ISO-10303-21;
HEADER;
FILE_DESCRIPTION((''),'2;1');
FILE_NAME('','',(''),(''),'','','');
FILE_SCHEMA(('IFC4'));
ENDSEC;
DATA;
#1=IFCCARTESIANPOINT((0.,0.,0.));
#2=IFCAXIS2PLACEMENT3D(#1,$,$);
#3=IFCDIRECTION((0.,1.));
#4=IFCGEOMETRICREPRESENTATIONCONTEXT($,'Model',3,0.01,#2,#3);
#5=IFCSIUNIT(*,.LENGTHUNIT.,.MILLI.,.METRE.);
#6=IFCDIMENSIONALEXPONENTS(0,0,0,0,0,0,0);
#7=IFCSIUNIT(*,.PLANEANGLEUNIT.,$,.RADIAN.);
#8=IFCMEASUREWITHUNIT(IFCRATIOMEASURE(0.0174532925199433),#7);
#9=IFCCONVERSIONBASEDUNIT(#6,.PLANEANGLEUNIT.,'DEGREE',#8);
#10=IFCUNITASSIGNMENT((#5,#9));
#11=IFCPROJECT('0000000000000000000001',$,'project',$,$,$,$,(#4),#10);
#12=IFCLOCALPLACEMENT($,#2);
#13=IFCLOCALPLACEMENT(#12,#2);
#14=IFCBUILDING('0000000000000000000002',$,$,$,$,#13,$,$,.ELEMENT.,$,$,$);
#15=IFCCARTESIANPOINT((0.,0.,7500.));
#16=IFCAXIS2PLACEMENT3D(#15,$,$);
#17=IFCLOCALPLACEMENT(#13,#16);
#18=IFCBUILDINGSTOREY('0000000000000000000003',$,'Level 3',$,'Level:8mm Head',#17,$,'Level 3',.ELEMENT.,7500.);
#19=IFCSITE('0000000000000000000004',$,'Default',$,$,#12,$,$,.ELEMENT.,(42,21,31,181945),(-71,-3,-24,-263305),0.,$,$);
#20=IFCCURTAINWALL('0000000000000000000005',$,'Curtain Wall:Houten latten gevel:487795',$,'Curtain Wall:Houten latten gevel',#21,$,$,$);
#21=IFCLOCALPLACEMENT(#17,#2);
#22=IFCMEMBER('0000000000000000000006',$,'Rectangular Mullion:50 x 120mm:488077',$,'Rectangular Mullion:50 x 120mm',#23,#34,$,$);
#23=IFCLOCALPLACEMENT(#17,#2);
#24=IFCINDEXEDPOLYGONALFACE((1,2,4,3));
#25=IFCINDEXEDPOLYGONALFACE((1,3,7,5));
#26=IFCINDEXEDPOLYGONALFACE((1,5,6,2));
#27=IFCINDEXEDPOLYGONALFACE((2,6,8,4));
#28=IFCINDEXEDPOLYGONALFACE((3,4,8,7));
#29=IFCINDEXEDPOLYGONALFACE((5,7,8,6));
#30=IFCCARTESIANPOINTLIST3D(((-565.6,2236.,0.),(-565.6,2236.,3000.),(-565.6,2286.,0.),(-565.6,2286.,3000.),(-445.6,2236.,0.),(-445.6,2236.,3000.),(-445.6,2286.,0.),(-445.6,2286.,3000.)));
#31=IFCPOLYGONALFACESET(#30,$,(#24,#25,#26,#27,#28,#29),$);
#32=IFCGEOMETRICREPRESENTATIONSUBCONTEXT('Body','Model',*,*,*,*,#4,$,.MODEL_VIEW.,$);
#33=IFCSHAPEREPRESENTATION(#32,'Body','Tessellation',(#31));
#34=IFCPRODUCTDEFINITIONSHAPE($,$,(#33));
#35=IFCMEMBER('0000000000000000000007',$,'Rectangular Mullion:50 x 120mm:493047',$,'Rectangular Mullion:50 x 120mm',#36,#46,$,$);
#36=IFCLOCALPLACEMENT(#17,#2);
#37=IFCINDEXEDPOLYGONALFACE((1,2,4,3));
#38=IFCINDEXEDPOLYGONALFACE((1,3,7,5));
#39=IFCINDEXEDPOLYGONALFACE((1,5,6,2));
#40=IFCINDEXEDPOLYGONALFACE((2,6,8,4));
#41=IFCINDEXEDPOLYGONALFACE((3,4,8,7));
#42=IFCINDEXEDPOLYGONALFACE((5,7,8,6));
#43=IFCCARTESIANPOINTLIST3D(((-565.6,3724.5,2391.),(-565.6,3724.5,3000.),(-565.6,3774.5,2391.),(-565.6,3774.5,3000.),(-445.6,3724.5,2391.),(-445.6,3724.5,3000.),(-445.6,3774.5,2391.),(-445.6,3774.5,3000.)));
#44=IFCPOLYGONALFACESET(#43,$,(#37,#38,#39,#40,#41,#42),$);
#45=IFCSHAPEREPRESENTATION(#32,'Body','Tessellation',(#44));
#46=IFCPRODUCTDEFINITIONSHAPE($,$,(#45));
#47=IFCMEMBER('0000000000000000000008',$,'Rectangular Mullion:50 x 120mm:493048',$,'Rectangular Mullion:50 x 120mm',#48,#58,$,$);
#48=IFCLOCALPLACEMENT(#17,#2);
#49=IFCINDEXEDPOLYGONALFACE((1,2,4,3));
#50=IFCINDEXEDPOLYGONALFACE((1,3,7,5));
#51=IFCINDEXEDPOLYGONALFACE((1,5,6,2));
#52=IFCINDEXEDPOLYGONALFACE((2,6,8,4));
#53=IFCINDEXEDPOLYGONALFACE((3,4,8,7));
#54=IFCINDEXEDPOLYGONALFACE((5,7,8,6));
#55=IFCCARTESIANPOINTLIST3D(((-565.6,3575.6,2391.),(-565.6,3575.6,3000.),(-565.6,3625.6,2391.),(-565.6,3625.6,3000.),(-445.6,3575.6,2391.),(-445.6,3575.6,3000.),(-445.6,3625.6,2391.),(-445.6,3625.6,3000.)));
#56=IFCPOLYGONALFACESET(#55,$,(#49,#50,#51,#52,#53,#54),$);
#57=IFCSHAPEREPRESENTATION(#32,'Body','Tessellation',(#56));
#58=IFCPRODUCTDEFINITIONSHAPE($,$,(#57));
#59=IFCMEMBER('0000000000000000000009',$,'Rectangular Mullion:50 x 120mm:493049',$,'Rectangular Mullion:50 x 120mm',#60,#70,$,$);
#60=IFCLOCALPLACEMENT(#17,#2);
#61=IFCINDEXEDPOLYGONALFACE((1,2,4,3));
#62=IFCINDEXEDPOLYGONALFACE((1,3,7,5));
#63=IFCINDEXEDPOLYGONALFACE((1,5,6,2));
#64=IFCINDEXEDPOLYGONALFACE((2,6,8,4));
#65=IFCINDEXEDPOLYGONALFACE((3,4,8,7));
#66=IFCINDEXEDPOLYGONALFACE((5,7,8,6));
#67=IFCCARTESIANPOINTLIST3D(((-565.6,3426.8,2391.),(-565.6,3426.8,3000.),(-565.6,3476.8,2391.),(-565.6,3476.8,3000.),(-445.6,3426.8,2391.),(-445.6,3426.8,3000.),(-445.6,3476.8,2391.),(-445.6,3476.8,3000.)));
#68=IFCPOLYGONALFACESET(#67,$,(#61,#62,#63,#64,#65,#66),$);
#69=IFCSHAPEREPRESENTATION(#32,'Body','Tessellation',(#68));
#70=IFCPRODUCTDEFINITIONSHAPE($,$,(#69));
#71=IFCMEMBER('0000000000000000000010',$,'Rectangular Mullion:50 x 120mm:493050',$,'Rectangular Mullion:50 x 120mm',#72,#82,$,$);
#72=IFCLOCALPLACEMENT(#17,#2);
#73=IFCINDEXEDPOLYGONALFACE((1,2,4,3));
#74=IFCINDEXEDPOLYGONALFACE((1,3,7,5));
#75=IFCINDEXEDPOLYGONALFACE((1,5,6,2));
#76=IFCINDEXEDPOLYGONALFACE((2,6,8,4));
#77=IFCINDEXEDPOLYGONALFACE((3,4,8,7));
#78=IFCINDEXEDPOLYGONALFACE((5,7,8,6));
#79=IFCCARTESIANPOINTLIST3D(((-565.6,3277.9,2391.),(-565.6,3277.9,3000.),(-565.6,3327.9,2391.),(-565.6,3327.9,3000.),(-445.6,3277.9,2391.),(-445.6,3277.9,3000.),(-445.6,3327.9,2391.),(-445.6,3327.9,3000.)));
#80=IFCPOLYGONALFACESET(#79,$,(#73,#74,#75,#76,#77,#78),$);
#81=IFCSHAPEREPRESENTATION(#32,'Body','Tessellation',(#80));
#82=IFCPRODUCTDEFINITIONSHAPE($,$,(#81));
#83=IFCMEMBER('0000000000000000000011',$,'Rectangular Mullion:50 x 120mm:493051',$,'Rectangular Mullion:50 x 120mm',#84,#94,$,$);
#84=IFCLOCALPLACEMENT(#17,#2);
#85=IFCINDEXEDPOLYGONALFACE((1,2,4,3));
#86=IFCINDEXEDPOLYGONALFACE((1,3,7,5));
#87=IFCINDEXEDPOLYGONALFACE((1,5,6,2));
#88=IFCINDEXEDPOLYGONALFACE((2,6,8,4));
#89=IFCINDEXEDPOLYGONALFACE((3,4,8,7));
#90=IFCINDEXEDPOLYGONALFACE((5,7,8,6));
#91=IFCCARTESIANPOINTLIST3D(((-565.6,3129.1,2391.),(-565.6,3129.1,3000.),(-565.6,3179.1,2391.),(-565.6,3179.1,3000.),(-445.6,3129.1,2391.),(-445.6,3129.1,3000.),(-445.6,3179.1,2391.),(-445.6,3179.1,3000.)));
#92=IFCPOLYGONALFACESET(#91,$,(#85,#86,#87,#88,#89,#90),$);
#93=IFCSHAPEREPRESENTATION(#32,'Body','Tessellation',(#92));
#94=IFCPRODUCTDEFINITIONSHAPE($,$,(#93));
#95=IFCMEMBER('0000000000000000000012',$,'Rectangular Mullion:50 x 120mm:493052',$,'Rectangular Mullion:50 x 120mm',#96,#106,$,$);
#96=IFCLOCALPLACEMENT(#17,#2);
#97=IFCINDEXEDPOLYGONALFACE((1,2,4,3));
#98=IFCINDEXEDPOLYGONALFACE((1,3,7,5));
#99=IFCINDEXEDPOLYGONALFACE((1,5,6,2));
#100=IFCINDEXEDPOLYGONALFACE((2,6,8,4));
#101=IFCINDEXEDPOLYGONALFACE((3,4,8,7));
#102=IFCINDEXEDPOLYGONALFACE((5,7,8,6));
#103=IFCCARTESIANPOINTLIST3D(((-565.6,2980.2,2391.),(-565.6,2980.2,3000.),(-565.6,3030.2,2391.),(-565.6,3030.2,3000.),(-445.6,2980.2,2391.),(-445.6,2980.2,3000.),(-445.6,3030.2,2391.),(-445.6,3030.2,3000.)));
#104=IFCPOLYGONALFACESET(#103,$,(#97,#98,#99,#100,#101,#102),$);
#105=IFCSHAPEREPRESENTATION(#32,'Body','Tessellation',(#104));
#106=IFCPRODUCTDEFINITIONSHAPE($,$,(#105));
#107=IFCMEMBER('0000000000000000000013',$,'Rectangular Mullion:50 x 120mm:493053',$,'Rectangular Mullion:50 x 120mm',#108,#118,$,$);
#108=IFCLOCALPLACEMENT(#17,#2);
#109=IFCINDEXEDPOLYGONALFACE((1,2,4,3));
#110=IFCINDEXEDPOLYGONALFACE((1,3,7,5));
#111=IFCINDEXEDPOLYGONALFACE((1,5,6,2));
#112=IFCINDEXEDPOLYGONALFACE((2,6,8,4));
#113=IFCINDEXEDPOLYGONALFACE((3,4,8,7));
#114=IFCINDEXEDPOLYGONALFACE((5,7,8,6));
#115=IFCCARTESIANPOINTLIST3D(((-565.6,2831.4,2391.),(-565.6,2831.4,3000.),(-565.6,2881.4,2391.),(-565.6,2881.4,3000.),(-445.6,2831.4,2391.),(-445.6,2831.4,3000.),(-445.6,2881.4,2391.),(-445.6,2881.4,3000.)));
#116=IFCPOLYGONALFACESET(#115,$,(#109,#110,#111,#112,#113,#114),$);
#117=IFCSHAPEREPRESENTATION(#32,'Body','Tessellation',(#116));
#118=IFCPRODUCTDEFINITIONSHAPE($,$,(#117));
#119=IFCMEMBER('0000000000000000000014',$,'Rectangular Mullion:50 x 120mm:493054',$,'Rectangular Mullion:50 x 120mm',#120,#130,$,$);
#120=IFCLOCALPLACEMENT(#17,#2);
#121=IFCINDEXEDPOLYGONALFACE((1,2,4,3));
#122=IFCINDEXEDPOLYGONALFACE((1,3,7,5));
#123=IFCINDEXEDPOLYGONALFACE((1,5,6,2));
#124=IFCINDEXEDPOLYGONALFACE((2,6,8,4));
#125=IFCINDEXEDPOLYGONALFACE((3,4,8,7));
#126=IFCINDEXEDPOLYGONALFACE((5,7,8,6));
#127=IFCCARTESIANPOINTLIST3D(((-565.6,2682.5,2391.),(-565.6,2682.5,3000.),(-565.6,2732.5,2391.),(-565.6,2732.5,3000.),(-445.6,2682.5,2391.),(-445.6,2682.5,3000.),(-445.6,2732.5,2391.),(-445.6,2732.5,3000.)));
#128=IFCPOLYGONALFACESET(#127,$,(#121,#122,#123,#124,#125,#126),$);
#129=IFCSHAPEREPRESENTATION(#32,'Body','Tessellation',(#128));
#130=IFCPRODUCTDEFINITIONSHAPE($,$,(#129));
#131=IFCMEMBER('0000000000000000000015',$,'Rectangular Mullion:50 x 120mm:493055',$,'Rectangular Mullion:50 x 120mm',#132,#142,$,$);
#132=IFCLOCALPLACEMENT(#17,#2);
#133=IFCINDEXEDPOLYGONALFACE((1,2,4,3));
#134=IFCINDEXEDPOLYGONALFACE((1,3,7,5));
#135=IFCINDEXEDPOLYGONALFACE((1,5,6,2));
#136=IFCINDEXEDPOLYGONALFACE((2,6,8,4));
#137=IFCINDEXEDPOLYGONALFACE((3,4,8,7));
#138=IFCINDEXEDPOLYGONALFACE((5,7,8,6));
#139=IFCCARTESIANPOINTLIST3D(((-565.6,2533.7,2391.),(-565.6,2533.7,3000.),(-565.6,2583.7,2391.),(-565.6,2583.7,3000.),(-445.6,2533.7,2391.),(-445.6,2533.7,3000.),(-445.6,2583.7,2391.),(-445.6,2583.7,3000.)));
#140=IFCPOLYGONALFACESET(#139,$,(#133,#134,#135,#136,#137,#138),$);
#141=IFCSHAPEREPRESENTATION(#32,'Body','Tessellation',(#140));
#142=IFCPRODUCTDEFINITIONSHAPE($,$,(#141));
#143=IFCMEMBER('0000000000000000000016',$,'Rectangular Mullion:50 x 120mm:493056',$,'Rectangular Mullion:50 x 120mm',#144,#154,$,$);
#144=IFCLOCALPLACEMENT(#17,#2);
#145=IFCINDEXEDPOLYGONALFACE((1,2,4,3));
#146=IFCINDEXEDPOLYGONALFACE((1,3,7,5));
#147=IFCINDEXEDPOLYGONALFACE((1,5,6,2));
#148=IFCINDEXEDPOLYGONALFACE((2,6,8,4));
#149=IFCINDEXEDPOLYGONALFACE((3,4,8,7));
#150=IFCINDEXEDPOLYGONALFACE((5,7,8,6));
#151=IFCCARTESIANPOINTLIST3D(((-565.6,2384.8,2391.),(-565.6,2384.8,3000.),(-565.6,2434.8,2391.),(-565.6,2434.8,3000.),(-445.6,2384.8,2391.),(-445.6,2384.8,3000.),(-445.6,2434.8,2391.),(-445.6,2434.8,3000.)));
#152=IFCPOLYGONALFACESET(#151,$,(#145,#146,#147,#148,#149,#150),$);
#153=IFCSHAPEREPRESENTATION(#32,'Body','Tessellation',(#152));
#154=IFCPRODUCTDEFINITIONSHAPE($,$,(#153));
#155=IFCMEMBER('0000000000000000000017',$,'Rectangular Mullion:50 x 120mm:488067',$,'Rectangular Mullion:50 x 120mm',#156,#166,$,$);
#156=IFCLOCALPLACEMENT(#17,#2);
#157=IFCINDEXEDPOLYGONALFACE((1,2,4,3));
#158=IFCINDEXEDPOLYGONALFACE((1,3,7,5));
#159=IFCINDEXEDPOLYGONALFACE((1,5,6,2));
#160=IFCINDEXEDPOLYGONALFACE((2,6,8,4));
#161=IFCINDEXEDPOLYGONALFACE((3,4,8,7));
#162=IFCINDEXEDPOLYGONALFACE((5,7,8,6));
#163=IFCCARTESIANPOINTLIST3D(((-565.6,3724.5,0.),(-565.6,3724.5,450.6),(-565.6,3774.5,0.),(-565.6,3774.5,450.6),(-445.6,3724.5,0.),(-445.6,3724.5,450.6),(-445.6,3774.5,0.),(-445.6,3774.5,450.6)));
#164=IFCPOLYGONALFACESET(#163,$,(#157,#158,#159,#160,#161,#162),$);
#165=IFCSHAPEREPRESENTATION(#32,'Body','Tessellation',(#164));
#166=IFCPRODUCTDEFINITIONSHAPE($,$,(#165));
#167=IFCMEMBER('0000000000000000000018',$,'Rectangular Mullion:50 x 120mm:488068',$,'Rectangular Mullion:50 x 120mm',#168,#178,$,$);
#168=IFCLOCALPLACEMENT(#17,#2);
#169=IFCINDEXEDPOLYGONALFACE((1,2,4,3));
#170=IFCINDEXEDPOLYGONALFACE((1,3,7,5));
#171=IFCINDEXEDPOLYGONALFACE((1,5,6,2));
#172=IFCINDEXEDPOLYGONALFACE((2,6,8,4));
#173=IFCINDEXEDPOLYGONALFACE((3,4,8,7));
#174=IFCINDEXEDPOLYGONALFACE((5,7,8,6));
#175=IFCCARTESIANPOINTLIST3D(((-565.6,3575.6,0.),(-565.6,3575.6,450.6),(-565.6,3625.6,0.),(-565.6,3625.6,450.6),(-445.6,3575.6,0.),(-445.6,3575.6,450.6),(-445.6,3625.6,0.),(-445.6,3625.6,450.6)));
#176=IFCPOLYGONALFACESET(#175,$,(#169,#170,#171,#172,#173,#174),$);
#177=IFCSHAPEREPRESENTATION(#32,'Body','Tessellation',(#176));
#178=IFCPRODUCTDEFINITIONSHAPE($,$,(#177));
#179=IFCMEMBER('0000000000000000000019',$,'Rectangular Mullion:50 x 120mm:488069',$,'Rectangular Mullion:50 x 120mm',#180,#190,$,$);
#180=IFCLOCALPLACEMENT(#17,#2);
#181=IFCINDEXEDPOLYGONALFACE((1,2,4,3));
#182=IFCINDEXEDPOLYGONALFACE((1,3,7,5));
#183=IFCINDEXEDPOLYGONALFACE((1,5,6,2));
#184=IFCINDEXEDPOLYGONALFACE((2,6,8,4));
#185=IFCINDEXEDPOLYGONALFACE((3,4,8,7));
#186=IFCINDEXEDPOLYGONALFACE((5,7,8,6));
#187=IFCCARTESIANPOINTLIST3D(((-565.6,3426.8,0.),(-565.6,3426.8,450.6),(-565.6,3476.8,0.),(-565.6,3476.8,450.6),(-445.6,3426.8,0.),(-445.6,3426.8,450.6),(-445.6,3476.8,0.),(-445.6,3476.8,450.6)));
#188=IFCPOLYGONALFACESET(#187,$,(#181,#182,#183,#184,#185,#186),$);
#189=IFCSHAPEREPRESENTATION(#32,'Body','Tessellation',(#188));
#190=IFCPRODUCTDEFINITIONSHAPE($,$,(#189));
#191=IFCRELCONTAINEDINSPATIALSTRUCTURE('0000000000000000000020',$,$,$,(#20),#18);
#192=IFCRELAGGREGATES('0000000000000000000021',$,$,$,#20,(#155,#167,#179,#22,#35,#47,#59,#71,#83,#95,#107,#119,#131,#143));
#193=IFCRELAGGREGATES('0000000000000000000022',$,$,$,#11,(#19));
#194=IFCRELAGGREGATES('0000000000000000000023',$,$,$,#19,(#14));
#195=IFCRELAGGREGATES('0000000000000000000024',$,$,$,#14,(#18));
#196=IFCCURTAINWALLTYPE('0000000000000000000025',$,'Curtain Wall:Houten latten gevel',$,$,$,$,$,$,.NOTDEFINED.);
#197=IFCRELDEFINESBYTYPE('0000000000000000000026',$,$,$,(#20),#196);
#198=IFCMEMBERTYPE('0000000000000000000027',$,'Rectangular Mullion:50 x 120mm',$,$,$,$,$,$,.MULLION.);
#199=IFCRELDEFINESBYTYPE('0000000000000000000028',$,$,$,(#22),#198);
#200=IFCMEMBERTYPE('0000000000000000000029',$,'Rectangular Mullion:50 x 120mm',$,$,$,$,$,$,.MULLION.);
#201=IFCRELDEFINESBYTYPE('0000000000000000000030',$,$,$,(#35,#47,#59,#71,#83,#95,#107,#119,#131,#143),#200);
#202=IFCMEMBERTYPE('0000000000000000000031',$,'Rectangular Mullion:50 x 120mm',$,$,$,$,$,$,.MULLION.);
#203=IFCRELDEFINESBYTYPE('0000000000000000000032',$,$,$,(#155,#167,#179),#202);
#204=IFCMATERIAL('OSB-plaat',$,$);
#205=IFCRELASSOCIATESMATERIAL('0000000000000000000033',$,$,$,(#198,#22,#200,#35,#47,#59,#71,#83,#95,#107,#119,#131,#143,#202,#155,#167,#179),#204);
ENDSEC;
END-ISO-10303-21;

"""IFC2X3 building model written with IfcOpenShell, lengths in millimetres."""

from ifc_helpers import new_model, entity, si_unit, converted_unit, direction, frame, origin, origin_2d_with_axis, place, context, subcontext, project, spatial, rectangle, extrude, source, transform, mapped, material, type_object, type_shapes, element, aggregate, save


model = new_model("IFC2X3")

# Units and contexts
model_context = context("Model", 3, precision=0.01, world=origin(), true_north=direction((0.0, 1.0)))
body_context = subcontext(model_context, "Body", "Model", "MODEL_VIEW")
ifc_project = project(units=[si_unit("LENGTHUNIT", "METRE", prefix="MILLI"), converted_unit("PLANEANGLEUNIT", "DEGREE", entity("IfcRatioMeasure", 0.0174532925199433), si_unit("PLANEANGLEUNIT", "RADIAN"), dimensions=[0, 0, 0, 0, 0, 0, 0])], contexts=[model_context])

# Site, building, storey
site_placement = place(None, frame((0.0, 0.0, 0.0)))
site = spatial("IfcSite", under=ifc_project, at=site_placement, Name="Default", CompositionType="ELEMENT", RefLatitude=(42, 21, 31, 181945), RefLongitude=(-71, -3, -24, -263305), RefElevation=0.0)
building_placement = place(site_placement, origin())
building = spatial("IfcBuilding", under=site, at=building_placement, CompositionType="ELEMENT")
storey_placement = place(building_placement, frame((0.0, 0.0, 7500.0)))
storey = spatial("IfcBuildingStorey", under=building, at=storey_placement, Name="Level 3", ObjectType="Level:8mm Head", LongName="Level 3", CompositionType="ELEMENT", Elevation=7500.0)

# Curtain wall, members
curtain_wall_type = type_object("IfcCurtainWallType", Name="Curtain Wall:Houten latten gevel", PredefinedType="NOTDEFINED")
curtain_wall_placement = place(storey_placement, frame((0.0, 0.0, -7500.0)))
curtain_wall = element("IfcCurtainWall", 1, at=curtain_wall_placement, inside=storey, type_object=curtain_wall_type, Name="Curtain Wall:Houten latten gevel:487795", ObjectType="Curtain Wall:Houten latten gevel")
ifc_material_1 = material(Name="OSB-plaat")
member_type_1 = type_object("IfcMemberType", Name="Rectangular Mullion:50 x 120mm", PredefinedType="MULLION", material=ifc_material_1)
shared_shape_1 = source(origin(), body_context, "Body", "SweptSolid", [
    extrude(rectangle(XDim=120.0, YDim=50.0, at=origin_2d_with_axis()), frame((0.0, 0.0, -3000.0), z_axis=(0.0, 0.0, 1.0), x_axis=(0.0, -1.0, 0.0)), (0.0, 0.0, 1.0), 3000.0),
])
type_shapes(member_type_1, [shared_shape_1])
member_1_placement = place(storey_placement, frame((-505.6, 2261.0, 0.0), z_axis=(0.0, 0.0, -1.0), x_axis=(0.0, -1.0, 0.0)))
member_1 = element("IfcMember", 2, at=member_1_placement, type_object=member_type_1, material=ifc_material_1, Name="Rectangular Mullion:50 x 120mm:488077", ObjectType="Rectangular Mullion:50 x 120mm", context=body_context, shape_type="MappedRepresentation", body=[
    mapped(shared_shape_1, transform((0.0, 0.0, 0.0), scale=1.0)),
])
member_type_2 = type_object("IfcMemberType", Name="Rectangular Mullion:50 x 120mm", PredefinedType="MULLION", material=ifc_material_1)
shared_shape_2 = source(origin(), body_context, "Body", "SweptSolid", [
    extrude(rectangle(XDim=120.0, YDim=50.0, at=origin_2d_with_axis()), frame((0.0, 0.0, -609.0), z_axis=(0.0, 0.0, 1.0), x_axis=(0.0, -1.0, 0.0)), (0.0, 0.0, 1.0), 609.0),
])
type_shapes(member_type_2, [shared_shape_2])
member_2_placement = place(storey_placement, frame((-505.6, 3749.5, 2391.0), z_axis=(0.0, 0.0, -1.0), x_axis=(0.0, -1.0, 0.0)))
member_2 = element("IfcMember", 3, at=member_2_placement, type_object=member_type_2, material=ifc_material_1, Name="Rectangular Mullion:50 x 120mm:493047", ObjectType="Rectangular Mullion:50 x 120mm", context=body_context, shape_type="MappedRepresentation", body=[
    mapped(shared_shape_2, transform((0.0, 0.0, 0.0), scale=1.0)),
])
member_3_placement = place(storey_placement, frame((-505.6, 3600.6, 2391.0), z_axis=(0.0, 0.0, -1.0), x_axis=(0.0, -1.0, 0.0)))
member_3 = element("IfcMember", 4, at=member_3_placement, type_object=member_type_2, material=ifc_material_1, Name="Rectangular Mullion:50 x 120mm:493048", ObjectType="Rectangular Mullion:50 x 120mm", context=body_context, shape_type="MappedRepresentation", body=[
    mapped(shared_shape_2, transform((0.0, 0.0, 0.0), scale=1.0)),
])
member_4_placement = place(storey_placement, frame((-505.6, 3451.8, 2391.0), z_axis=(0.0, 0.0, -1.0), x_axis=(0.0, -1.0, 0.0)))
member_4 = element("IfcMember", 5, at=member_4_placement, type_object=member_type_2, material=ifc_material_1, Name="Rectangular Mullion:50 x 120mm:493049", ObjectType="Rectangular Mullion:50 x 120mm", context=body_context, shape_type="MappedRepresentation", body=[
    mapped(shared_shape_2, transform((0.0, 0.0, 0.0), scale=1.0)),
])
member_5_placement = place(storey_placement, frame((-505.6, 3302.9, 2391.0), z_axis=(0.0, 0.0, -1.0), x_axis=(0.0, -1.0, 0.0)))
member_5 = element("IfcMember", 6, at=member_5_placement, type_object=member_type_2, material=ifc_material_1, Name="Rectangular Mullion:50 x 120mm:493050", ObjectType="Rectangular Mullion:50 x 120mm", context=body_context, shape_type="MappedRepresentation", body=[
    mapped(shared_shape_2, transform((0.0, 0.0, 0.0), scale=1.0)),
])
member_6_placement = place(storey_placement, frame((-505.6, 3154.1, 2391.0), z_axis=(0.0, 0.0, -1.0), x_axis=(0.0, -1.0, 0.0)))
member_6 = element("IfcMember", 7, at=member_6_placement, type_object=member_type_2, material=ifc_material_1, Name="Rectangular Mullion:50 x 120mm:493051", ObjectType="Rectangular Mullion:50 x 120mm", context=body_context, shape_type="MappedRepresentation", body=[
    mapped(shared_shape_2, transform((0.0, 0.0, 0.0), scale=1.0)),
])
member_7_placement = place(storey_placement, frame((-505.6, 3005.2, 2391.0), z_axis=(0.0, 0.0, -1.0), x_axis=(0.0, -1.0, 0.0)))
member_7 = element("IfcMember", 8, at=member_7_placement, type_object=member_type_2, material=ifc_material_1, Name="Rectangular Mullion:50 x 120mm:493052", ObjectType="Rectangular Mullion:50 x 120mm", context=body_context, shape_type="MappedRepresentation", body=[
    mapped(shared_shape_2, transform((0.0, 0.0, 0.0), scale=1.0)),
])
member_8_placement = place(storey_placement, frame((-505.6, 2856.4, 2391.0), z_axis=(0.0, 0.0, -1.0), x_axis=(0.0, -1.0, 0.0)))
member_8 = element("IfcMember", 9, at=member_8_placement, type_object=member_type_2, material=ifc_material_1, Name="Rectangular Mullion:50 x 120mm:493053", ObjectType="Rectangular Mullion:50 x 120mm", context=body_context, shape_type="MappedRepresentation", body=[
    mapped(shared_shape_2, transform((0.0, 0.0, 0.0), scale=1.0)),
])
member_9_placement = place(storey_placement, frame((-505.6, 2707.5, 2391.0), z_axis=(0.0, 0.0, -1.0), x_axis=(0.0, -1.0, 0.0)))
member_9 = element("IfcMember", 10, at=member_9_placement, type_object=member_type_2, material=ifc_material_1, Name="Rectangular Mullion:50 x 120mm:493054", ObjectType="Rectangular Mullion:50 x 120mm", context=body_context, shape_type="MappedRepresentation", body=[
    mapped(shared_shape_2, transform((0.0, 0.0, 0.0), scale=1.0)),
])
member_10_placement = place(storey_placement, frame((-505.6, 2558.7, 2391.0), z_axis=(0.0, 0.0, -1.0), x_axis=(0.0, -1.0, 0.0)))
member_10 = element("IfcMember", 11, at=member_10_placement, type_object=member_type_2, material=ifc_material_1, Name="Rectangular Mullion:50 x 120mm:493055", ObjectType="Rectangular Mullion:50 x 120mm", context=body_context, shape_type="MappedRepresentation", body=[
    mapped(shared_shape_2, transform((0.0, 0.0, 0.0), scale=1.0)),
])
member_11_placement = place(storey_placement, frame((-505.6, 2409.8, 2391.0), z_axis=(0.0, 0.0, -1.0), x_axis=(0.0, -1.0, 0.0)))
member_11 = element("IfcMember", 12, at=member_11_placement, type_object=member_type_2, material=ifc_material_1, Name="Rectangular Mullion:50 x 120mm:493056", ObjectType="Rectangular Mullion:50 x 120mm", context=body_context, shape_type="MappedRepresentation", body=[
    mapped(shared_shape_2, transform((0.0, 0.0, 0.0), scale=1.0)),
])
member_type_3 = type_object("IfcMemberType", Name="Rectangular Mullion:50 x 120mm", PredefinedType="MULLION", material=ifc_material_1)
shared_shape_3 = source(origin(), body_context, "Body", "SweptSolid", [
    extrude(rectangle(XDim=120.0, YDim=50.0, at=origin_2d_with_axis()), frame((0.0, 0.0, -450.6), z_axis=(0.0, 0.0, 1.0), x_axis=(0.0, -1.0, 0.0)), (0.0, 0.0, 1.0), 450.6),
])
type_shapes(member_type_3, [shared_shape_3])
member_12_placement = place(storey_placement, frame((-505.6, 3749.5, 0.0), z_axis=(0.0, 0.0, -1.0), x_axis=(0.0, -1.0, 0.0)))
member_12 = element("IfcMember", 13, at=member_12_placement, type_object=member_type_3, material=ifc_material_1, Name="Rectangular Mullion:50 x 120mm:488067", ObjectType="Rectangular Mullion:50 x 120mm", context=body_context, shape_type="MappedRepresentation", body=[
    mapped(shared_shape_3, transform((0.0, 0.0, 0.0), scale=1.0)),
])
member_13_placement = place(storey_placement, frame((-505.6, 3600.6, 0.0), z_axis=(0.0, 0.0, -1.0), x_axis=(0.0, -1.0, 0.0)))
member_13 = element("IfcMember", 14, at=member_13_placement, type_object=member_type_3, material=ifc_material_1, Name="Rectangular Mullion:50 x 120mm:488068", ObjectType="Rectangular Mullion:50 x 120mm", context=body_context, shape_type="MappedRepresentation", body=[
    mapped(shared_shape_3, transform((0.0, 0.0, 0.0), scale=1.0)),
])
member_14_placement = place(storey_placement, frame((-505.6, 3451.8, 0.0), z_axis=(0.0, 0.0, -1.0), x_axis=(0.0, -1.0, 0.0)))
member_14 = element("IfcMember", 15, at=member_14_placement, type_object=member_type_3, material=ifc_material_1, Name="Rectangular Mullion:50 x 120mm:488069", ObjectType="Rectangular Mullion:50 x 120mm", context=body_context, shape_type="MappedRepresentation", body=[
    mapped(shared_shape_3, transform((0.0, 0.0, 0.0), scale=1.0)),
])
aggregate(curtain_wall, [member_12, member_13, member_14, member_1, member_2, member_3, member_4, member_5, member_6, member_7, member_8, member_9, member_10, member_11])

save(model, "model.ifc")
